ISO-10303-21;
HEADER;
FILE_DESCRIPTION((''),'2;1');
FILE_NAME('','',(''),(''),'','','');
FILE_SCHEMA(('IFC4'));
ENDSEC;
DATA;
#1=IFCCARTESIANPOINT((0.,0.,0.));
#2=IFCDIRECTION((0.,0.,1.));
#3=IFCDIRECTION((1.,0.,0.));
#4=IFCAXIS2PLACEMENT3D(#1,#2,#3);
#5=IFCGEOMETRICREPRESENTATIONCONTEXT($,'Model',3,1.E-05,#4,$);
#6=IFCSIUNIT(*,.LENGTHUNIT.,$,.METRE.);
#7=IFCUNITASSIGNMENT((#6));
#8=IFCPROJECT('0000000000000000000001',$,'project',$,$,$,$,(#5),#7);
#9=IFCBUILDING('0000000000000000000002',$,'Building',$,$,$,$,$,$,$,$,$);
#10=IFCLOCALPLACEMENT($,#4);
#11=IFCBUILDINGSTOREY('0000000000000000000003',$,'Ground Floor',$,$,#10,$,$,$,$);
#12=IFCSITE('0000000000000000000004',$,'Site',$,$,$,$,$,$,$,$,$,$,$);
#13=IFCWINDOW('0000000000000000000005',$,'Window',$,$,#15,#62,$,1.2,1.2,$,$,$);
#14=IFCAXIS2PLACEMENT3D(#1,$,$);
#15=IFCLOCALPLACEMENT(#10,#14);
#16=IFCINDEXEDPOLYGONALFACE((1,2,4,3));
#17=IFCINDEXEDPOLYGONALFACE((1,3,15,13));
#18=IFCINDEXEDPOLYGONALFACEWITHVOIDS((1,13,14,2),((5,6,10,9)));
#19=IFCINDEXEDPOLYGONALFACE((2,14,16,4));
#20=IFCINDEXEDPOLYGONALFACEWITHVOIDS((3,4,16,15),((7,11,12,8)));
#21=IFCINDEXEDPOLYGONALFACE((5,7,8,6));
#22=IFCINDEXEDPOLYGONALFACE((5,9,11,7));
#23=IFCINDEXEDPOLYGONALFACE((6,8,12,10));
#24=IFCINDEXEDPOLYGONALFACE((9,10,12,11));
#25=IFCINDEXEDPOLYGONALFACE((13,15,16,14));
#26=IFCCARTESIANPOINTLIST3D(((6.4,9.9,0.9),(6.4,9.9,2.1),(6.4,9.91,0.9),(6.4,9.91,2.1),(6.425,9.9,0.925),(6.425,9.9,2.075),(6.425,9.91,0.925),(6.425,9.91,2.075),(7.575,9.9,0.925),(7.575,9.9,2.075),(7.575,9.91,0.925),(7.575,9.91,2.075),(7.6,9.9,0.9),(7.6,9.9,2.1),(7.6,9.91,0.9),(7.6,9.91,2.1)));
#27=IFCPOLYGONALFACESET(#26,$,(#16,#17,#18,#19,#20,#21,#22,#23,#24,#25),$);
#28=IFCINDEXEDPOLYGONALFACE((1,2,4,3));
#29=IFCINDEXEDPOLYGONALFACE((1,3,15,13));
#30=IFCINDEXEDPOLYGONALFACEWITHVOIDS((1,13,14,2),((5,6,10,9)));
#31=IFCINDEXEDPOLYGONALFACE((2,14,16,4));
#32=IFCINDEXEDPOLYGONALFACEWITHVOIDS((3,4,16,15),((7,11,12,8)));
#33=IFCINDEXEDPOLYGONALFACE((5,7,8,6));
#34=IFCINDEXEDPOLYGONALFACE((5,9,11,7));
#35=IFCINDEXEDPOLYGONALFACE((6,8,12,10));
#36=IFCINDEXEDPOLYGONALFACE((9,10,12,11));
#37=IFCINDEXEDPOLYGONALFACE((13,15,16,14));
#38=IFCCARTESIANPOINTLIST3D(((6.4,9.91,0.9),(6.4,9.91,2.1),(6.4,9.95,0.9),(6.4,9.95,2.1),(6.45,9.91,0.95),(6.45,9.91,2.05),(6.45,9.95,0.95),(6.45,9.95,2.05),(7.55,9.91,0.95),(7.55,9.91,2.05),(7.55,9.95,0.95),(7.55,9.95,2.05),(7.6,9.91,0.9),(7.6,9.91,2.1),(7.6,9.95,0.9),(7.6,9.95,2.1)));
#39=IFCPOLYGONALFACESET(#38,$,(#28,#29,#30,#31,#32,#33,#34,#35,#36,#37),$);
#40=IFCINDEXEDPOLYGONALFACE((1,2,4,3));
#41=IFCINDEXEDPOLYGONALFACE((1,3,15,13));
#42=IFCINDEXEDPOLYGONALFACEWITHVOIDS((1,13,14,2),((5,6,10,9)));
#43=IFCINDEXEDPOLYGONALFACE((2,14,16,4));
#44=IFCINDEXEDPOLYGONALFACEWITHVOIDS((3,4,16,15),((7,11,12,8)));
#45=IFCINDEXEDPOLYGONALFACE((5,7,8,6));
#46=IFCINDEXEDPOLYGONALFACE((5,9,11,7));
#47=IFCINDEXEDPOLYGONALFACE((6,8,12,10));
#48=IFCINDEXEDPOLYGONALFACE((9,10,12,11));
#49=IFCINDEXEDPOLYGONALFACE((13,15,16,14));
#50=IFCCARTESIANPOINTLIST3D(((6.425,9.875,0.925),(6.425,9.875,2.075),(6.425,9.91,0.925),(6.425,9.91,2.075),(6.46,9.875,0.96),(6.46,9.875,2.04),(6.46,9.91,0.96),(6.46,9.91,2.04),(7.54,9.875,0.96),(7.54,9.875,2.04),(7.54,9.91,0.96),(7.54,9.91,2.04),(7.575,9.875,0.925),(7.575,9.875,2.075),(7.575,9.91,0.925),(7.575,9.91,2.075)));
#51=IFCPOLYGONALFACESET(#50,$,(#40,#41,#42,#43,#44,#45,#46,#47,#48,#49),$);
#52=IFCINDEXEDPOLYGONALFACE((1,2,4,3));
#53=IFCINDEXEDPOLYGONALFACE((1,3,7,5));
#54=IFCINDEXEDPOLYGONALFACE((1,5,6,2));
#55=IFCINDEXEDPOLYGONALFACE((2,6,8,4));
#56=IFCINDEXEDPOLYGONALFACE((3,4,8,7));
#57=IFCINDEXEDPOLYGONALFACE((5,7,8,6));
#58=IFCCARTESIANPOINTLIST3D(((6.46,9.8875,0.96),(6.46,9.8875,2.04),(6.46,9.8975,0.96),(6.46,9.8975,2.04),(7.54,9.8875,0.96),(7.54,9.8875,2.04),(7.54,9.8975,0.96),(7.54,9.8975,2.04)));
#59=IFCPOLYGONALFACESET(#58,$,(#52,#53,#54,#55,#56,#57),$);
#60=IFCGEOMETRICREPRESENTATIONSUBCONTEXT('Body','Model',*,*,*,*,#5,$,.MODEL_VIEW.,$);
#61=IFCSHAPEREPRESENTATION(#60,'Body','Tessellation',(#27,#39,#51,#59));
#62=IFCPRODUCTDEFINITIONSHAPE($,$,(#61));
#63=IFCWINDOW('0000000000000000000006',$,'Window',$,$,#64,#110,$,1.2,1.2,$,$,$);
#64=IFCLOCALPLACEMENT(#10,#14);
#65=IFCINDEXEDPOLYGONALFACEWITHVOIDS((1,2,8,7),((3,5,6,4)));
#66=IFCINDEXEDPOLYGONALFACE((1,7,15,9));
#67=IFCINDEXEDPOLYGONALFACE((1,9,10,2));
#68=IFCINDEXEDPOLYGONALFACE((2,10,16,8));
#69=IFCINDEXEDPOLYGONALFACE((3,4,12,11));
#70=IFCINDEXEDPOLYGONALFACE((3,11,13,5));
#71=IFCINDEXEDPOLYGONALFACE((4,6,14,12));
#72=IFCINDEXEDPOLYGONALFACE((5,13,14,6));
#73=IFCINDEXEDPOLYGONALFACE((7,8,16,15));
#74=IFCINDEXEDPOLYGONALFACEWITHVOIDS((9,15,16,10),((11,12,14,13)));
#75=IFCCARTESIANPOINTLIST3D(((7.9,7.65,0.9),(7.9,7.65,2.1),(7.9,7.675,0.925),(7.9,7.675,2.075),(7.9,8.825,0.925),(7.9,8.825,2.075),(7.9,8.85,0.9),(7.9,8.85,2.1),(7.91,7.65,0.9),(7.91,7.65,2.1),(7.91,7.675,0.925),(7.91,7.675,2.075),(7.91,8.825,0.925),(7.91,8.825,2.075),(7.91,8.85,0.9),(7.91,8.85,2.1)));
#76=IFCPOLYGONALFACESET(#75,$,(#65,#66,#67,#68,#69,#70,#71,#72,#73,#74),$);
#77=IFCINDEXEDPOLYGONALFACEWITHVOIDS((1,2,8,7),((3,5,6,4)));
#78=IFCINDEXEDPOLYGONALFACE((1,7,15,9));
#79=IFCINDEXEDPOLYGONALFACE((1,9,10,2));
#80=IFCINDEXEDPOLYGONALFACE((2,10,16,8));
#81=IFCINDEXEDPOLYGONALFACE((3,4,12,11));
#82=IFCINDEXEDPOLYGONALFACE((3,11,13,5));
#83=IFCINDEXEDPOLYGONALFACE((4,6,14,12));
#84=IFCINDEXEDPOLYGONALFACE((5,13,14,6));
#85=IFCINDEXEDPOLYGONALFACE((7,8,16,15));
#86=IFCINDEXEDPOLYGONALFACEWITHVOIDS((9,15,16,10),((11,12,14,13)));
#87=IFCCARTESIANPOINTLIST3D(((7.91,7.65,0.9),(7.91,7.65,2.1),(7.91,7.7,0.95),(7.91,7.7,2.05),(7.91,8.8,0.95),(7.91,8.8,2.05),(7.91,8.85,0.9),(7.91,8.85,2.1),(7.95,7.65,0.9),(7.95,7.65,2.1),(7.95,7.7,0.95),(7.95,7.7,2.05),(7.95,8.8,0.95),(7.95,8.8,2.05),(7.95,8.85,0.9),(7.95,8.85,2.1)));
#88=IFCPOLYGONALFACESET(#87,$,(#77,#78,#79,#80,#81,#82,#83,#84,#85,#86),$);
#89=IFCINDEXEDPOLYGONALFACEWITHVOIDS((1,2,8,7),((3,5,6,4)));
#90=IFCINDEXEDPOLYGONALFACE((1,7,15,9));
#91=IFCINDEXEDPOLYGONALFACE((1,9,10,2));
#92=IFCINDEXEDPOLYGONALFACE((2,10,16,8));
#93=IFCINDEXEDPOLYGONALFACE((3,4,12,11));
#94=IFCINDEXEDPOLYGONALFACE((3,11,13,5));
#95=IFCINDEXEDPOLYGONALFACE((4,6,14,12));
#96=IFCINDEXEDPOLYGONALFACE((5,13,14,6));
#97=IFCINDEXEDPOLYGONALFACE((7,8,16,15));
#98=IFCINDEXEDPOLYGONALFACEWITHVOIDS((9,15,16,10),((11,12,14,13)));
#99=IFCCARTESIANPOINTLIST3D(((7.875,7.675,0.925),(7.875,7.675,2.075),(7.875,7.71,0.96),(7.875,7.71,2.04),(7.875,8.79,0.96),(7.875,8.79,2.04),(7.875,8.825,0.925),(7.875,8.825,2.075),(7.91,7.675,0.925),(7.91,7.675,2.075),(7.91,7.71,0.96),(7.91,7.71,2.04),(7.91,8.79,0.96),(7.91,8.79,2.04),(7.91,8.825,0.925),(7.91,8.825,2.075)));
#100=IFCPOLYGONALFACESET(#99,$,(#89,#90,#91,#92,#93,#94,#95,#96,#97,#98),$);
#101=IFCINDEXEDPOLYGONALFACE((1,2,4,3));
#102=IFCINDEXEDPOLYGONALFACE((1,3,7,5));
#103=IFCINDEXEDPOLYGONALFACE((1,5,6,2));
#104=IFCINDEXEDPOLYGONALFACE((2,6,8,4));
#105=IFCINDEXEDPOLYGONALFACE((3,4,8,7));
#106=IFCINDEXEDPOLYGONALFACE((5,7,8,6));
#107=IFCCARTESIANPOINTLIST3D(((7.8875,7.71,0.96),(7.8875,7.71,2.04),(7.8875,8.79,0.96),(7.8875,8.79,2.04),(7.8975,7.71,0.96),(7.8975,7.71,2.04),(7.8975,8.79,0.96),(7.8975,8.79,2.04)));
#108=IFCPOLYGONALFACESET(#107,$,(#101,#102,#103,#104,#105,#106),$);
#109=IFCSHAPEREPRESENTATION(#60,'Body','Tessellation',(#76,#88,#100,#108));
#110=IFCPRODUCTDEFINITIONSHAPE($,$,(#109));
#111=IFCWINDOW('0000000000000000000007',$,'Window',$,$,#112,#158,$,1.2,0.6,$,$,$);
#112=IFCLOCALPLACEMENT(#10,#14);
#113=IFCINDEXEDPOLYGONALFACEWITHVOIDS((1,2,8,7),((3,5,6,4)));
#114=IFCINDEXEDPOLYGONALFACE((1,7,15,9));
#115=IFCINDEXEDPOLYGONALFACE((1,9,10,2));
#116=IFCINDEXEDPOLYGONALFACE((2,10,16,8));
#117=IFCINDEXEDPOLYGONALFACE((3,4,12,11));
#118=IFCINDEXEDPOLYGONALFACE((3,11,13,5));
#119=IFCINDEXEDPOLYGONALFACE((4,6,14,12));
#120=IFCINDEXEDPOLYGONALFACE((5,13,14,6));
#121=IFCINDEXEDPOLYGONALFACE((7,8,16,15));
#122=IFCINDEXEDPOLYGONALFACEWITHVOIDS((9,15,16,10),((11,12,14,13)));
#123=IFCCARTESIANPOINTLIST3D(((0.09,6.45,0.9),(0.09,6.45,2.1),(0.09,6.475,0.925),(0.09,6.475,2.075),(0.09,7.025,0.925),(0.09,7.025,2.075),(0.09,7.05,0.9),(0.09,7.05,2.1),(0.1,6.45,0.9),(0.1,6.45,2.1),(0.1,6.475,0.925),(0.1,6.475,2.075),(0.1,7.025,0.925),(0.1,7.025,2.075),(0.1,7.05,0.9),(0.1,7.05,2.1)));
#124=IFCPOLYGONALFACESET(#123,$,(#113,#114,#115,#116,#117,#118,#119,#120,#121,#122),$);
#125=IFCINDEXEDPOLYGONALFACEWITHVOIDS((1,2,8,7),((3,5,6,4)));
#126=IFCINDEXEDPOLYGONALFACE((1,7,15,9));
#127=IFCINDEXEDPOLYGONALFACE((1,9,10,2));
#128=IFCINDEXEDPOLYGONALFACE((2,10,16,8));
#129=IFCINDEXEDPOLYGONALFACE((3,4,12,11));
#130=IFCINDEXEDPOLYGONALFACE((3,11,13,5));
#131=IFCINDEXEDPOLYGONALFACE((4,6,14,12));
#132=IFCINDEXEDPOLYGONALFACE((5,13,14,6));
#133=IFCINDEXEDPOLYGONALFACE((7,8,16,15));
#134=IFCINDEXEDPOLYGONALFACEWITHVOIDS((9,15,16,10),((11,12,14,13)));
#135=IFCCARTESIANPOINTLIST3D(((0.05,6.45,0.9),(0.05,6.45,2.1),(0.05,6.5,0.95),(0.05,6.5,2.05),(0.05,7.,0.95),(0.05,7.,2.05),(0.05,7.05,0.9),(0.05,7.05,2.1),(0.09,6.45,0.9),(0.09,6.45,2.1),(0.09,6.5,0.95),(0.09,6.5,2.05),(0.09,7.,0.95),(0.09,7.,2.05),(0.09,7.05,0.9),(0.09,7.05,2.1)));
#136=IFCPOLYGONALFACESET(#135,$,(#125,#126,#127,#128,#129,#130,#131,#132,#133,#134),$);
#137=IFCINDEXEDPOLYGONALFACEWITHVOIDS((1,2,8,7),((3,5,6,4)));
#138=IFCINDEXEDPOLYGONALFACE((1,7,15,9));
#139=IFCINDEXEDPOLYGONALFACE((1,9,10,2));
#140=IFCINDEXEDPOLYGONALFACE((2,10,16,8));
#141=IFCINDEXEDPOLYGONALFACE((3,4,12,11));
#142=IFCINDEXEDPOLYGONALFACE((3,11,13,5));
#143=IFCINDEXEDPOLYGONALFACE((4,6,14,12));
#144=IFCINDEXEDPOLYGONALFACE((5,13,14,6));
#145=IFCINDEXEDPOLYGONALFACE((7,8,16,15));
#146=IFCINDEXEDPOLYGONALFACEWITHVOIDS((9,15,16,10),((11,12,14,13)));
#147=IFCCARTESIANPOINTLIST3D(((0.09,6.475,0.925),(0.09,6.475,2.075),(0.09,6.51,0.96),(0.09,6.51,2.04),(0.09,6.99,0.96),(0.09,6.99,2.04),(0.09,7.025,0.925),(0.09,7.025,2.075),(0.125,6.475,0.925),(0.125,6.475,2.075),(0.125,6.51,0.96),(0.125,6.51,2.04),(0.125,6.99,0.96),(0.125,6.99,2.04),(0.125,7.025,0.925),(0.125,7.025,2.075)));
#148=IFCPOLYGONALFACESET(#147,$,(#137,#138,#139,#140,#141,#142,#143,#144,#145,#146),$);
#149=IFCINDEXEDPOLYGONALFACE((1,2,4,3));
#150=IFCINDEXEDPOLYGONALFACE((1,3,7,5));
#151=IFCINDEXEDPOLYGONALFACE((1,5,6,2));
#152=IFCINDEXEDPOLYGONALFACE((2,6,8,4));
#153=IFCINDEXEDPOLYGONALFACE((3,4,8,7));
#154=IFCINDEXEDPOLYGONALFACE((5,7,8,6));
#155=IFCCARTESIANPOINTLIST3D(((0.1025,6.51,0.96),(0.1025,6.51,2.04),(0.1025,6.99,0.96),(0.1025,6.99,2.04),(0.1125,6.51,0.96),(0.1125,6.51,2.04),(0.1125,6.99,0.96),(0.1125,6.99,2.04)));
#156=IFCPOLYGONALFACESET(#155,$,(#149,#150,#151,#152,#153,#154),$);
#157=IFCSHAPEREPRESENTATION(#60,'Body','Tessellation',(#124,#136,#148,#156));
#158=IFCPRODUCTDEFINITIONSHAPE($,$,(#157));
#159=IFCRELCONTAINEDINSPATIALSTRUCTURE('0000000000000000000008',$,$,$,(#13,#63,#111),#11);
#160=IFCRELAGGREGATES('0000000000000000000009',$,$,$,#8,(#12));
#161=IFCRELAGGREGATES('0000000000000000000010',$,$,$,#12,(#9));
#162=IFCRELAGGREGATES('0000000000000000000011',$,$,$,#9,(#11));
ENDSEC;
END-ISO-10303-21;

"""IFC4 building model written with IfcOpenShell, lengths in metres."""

from ifc_helpers import new_model, si_unit, frame, origin_with_axes, place, context, subcontext, project, spatial, line, indexed_curve, outline, extrude, element, save


model = new_model("IFC4")

# Units and contexts
model_context = context("Model", 3, precision=1e-05, world=origin_with_axes())
body_context = subcontext(model_context, "Body", "Model", "MODEL_VIEW")
ifc_project = project(units=[si_unit("LENGTHUNIT", "METRE")], contexts=[model_context])

# Site, building, storey
site = spatial("IfcSite", under=ifc_project, Name="Site")
building = spatial("IfcBuilding", under=site, Name="Building")
storey_placement = place(None, origin_with_axes())
storey = spatial("IfcBuildingStorey", under=building, at=storey_placement, Name="Ground Floor")

# Windows
for number, where, z_axis, x_axis, name in (
    (1, (7.6, 10.0, 0.9), (0.0, 0.0, 1.0), (-1.0, 0.0, 0.0), "Window"),
    (2, (8.0, 7.65, 0.9), (0.0, 0.0, 1.0), (0.0, 1.0, 0.0), "Window"),
):
    element("IfcWindow", number, at=place(storey_placement, frame(where, z_axis=z_axis, x_axis=x_axis)), inside=storey, Name=name, OverallHeight=1.2, OverallWidth=1.2, context=body_context, shape_type="SweptSolid", body=[
        extrude(outline(indexed_curve([(0.0, 0.0), (1.2, 0.0), (1.2, 1.2), (0.0, 1.2)], segments=[line(1, 2, 3, 4, 1)]), holes=[indexed_curve([(0.025, 0.025), (1.175, 0.025), (1.175, 1.175), (0.025, 1.175)], segments=[line(1, 2, 3, 4, 1)])]), frame((0.0, 0.09, 0.0), z_axis=(0.0, -1.0, 0.0), x_axis=(1.0, 0.0, 0.0)), (0.0, 0.0, -1.0), 0.01),
        extrude(outline(indexed_curve([(0.0, 0.0), (1.2, 0.0), (1.2, 1.2), (0.0, 1.2)], segments=[line(1, 2, 3, 4, 1)]), holes=[indexed_curve([(0.05, 0.05), (1.15, 0.05), (1.15, 1.15), (0.05, 1.15)], segments=[line(1, 2, 3, 4, 1)])]), frame((0.0, 0.05, 0.0), z_axis=(0.0, -1.0, 0.0), x_axis=(1.0, 0.0, 0.0)), (0.0, 0.0, -1.0), 0.04),
        extrude(outline(indexed_curve([(0.0, 0.0), (1.15, 0.0), (1.15, 1.15), (0.0, 1.15)], segments=[line(1, 2, 3, 4, 1)]), holes=[indexed_curve([(0.035, 0.035), (1.115, 0.035), (1.115, 1.115), (0.035, 1.115)], segments=[line(1, 2, 3, 4, 1)])]), frame((0.025, 0.09, 0.025), z_axis=(0.0, -1.0, 0.0), x_axis=(1.0, 0.0, 0.0)), (0.0, 0.0, -1.0), 0.035),
        extrude(outline(indexed_curve([(0.035, 0.035), (1.115, 0.035), (1.115, 1.115), (0.035, 1.115)], segments=[line(1, 2, 3, 4, 1)])), frame((0.025, 0.1025, 0.025), z_axis=(0.0, -1.0, 0.0), x_axis=(1.0, 0.0, 0.0)), (0.0, 0.0, -1.0), 0.01),
    ])
window_1_placement = place(storey_placement, frame((0.0, 7.05, 0.9), z_axis=(0.0, 0.0, 1.0), x_axis=(0.0, -1.0, 0.0)))
element("IfcWindow", 3, at=window_1_placement, inside=storey, Name="Window", OverallHeight=1.2, OverallWidth=0.6, context=body_context, shape_type="SweptSolid", body=[
    extrude(outline(indexed_curve([(0.0, 0.0), (0.6, 0.0), (0.6, 1.2), (0.0, 1.2)], segments=[line(1, 2, 3, 4, 1)]), holes=[indexed_curve([(0.025, 0.025), (0.575, 0.025), (0.575, 1.175), (0.025, 1.175)], segments=[line(1, 2, 3, 4, 1)])]), frame((0.0, 0.09, 0.0), z_axis=(0.0, -1.0, 0.0), x_axis=(1.0, 0.0, 0.0)), (0.0, 0.0, -1.0), 0.01),
    extrude(outline(indexed_curve([(0.0, 0.0), (0.6, 0.0), (0.6, 1.2), (0.0, 1.2)], segments=[line(1, 2, 3, 4, 1)]), holes=[indexed_curve([(0.05, 0.05), (0.55, 0.05), (0.55, 1.15), (0.05, 1.15)], segments=[line(1, 2, 3, 4, 1)])]), frame((0.0, 0.05, 0.0), z_axis=(0.0, -1.0, 0.0), x_axis=(1.0, 0.0, 0.0)), (0.0, 0.0, -1.0), 0.04),
    extrude(outline(indexed_curve([(0.0, 0.0), (0.55, 0.0), (0.55, 1.15), (0.0, 1.15)], segments=[line(1, 2, 3, 4, 1)]), holes=[indexed_curve([(0.035, 0.035), (0.515, 0.035), (0.515, 1.115), (0.035, 1.115)], segments=[line(1, 2, 3, 4, 1)])]), frame((0.025, 0.09, 0.025), z_axis=(0.0, -1.0, 0.0), x_axis=(1.0, 0.0, 0.0)), (0.0, 0.0, -1.0), 0.035),
    extrude(outline(indexed_curve([(0.035, 0.035), (0.515, 0.035), (0.515, 1.115), (0.035, 1.115)], segments=[line(1, 2, 3, 4, 1)])), frame((0.025, 0.1025, 0.025), z_axis=(0.0, -1.0, 0.0), x_axis=(1.0, 0.0, 0.0)), (0.0, 0.0, -1.0), 0.01),
])

save(model, "model.ifc")
